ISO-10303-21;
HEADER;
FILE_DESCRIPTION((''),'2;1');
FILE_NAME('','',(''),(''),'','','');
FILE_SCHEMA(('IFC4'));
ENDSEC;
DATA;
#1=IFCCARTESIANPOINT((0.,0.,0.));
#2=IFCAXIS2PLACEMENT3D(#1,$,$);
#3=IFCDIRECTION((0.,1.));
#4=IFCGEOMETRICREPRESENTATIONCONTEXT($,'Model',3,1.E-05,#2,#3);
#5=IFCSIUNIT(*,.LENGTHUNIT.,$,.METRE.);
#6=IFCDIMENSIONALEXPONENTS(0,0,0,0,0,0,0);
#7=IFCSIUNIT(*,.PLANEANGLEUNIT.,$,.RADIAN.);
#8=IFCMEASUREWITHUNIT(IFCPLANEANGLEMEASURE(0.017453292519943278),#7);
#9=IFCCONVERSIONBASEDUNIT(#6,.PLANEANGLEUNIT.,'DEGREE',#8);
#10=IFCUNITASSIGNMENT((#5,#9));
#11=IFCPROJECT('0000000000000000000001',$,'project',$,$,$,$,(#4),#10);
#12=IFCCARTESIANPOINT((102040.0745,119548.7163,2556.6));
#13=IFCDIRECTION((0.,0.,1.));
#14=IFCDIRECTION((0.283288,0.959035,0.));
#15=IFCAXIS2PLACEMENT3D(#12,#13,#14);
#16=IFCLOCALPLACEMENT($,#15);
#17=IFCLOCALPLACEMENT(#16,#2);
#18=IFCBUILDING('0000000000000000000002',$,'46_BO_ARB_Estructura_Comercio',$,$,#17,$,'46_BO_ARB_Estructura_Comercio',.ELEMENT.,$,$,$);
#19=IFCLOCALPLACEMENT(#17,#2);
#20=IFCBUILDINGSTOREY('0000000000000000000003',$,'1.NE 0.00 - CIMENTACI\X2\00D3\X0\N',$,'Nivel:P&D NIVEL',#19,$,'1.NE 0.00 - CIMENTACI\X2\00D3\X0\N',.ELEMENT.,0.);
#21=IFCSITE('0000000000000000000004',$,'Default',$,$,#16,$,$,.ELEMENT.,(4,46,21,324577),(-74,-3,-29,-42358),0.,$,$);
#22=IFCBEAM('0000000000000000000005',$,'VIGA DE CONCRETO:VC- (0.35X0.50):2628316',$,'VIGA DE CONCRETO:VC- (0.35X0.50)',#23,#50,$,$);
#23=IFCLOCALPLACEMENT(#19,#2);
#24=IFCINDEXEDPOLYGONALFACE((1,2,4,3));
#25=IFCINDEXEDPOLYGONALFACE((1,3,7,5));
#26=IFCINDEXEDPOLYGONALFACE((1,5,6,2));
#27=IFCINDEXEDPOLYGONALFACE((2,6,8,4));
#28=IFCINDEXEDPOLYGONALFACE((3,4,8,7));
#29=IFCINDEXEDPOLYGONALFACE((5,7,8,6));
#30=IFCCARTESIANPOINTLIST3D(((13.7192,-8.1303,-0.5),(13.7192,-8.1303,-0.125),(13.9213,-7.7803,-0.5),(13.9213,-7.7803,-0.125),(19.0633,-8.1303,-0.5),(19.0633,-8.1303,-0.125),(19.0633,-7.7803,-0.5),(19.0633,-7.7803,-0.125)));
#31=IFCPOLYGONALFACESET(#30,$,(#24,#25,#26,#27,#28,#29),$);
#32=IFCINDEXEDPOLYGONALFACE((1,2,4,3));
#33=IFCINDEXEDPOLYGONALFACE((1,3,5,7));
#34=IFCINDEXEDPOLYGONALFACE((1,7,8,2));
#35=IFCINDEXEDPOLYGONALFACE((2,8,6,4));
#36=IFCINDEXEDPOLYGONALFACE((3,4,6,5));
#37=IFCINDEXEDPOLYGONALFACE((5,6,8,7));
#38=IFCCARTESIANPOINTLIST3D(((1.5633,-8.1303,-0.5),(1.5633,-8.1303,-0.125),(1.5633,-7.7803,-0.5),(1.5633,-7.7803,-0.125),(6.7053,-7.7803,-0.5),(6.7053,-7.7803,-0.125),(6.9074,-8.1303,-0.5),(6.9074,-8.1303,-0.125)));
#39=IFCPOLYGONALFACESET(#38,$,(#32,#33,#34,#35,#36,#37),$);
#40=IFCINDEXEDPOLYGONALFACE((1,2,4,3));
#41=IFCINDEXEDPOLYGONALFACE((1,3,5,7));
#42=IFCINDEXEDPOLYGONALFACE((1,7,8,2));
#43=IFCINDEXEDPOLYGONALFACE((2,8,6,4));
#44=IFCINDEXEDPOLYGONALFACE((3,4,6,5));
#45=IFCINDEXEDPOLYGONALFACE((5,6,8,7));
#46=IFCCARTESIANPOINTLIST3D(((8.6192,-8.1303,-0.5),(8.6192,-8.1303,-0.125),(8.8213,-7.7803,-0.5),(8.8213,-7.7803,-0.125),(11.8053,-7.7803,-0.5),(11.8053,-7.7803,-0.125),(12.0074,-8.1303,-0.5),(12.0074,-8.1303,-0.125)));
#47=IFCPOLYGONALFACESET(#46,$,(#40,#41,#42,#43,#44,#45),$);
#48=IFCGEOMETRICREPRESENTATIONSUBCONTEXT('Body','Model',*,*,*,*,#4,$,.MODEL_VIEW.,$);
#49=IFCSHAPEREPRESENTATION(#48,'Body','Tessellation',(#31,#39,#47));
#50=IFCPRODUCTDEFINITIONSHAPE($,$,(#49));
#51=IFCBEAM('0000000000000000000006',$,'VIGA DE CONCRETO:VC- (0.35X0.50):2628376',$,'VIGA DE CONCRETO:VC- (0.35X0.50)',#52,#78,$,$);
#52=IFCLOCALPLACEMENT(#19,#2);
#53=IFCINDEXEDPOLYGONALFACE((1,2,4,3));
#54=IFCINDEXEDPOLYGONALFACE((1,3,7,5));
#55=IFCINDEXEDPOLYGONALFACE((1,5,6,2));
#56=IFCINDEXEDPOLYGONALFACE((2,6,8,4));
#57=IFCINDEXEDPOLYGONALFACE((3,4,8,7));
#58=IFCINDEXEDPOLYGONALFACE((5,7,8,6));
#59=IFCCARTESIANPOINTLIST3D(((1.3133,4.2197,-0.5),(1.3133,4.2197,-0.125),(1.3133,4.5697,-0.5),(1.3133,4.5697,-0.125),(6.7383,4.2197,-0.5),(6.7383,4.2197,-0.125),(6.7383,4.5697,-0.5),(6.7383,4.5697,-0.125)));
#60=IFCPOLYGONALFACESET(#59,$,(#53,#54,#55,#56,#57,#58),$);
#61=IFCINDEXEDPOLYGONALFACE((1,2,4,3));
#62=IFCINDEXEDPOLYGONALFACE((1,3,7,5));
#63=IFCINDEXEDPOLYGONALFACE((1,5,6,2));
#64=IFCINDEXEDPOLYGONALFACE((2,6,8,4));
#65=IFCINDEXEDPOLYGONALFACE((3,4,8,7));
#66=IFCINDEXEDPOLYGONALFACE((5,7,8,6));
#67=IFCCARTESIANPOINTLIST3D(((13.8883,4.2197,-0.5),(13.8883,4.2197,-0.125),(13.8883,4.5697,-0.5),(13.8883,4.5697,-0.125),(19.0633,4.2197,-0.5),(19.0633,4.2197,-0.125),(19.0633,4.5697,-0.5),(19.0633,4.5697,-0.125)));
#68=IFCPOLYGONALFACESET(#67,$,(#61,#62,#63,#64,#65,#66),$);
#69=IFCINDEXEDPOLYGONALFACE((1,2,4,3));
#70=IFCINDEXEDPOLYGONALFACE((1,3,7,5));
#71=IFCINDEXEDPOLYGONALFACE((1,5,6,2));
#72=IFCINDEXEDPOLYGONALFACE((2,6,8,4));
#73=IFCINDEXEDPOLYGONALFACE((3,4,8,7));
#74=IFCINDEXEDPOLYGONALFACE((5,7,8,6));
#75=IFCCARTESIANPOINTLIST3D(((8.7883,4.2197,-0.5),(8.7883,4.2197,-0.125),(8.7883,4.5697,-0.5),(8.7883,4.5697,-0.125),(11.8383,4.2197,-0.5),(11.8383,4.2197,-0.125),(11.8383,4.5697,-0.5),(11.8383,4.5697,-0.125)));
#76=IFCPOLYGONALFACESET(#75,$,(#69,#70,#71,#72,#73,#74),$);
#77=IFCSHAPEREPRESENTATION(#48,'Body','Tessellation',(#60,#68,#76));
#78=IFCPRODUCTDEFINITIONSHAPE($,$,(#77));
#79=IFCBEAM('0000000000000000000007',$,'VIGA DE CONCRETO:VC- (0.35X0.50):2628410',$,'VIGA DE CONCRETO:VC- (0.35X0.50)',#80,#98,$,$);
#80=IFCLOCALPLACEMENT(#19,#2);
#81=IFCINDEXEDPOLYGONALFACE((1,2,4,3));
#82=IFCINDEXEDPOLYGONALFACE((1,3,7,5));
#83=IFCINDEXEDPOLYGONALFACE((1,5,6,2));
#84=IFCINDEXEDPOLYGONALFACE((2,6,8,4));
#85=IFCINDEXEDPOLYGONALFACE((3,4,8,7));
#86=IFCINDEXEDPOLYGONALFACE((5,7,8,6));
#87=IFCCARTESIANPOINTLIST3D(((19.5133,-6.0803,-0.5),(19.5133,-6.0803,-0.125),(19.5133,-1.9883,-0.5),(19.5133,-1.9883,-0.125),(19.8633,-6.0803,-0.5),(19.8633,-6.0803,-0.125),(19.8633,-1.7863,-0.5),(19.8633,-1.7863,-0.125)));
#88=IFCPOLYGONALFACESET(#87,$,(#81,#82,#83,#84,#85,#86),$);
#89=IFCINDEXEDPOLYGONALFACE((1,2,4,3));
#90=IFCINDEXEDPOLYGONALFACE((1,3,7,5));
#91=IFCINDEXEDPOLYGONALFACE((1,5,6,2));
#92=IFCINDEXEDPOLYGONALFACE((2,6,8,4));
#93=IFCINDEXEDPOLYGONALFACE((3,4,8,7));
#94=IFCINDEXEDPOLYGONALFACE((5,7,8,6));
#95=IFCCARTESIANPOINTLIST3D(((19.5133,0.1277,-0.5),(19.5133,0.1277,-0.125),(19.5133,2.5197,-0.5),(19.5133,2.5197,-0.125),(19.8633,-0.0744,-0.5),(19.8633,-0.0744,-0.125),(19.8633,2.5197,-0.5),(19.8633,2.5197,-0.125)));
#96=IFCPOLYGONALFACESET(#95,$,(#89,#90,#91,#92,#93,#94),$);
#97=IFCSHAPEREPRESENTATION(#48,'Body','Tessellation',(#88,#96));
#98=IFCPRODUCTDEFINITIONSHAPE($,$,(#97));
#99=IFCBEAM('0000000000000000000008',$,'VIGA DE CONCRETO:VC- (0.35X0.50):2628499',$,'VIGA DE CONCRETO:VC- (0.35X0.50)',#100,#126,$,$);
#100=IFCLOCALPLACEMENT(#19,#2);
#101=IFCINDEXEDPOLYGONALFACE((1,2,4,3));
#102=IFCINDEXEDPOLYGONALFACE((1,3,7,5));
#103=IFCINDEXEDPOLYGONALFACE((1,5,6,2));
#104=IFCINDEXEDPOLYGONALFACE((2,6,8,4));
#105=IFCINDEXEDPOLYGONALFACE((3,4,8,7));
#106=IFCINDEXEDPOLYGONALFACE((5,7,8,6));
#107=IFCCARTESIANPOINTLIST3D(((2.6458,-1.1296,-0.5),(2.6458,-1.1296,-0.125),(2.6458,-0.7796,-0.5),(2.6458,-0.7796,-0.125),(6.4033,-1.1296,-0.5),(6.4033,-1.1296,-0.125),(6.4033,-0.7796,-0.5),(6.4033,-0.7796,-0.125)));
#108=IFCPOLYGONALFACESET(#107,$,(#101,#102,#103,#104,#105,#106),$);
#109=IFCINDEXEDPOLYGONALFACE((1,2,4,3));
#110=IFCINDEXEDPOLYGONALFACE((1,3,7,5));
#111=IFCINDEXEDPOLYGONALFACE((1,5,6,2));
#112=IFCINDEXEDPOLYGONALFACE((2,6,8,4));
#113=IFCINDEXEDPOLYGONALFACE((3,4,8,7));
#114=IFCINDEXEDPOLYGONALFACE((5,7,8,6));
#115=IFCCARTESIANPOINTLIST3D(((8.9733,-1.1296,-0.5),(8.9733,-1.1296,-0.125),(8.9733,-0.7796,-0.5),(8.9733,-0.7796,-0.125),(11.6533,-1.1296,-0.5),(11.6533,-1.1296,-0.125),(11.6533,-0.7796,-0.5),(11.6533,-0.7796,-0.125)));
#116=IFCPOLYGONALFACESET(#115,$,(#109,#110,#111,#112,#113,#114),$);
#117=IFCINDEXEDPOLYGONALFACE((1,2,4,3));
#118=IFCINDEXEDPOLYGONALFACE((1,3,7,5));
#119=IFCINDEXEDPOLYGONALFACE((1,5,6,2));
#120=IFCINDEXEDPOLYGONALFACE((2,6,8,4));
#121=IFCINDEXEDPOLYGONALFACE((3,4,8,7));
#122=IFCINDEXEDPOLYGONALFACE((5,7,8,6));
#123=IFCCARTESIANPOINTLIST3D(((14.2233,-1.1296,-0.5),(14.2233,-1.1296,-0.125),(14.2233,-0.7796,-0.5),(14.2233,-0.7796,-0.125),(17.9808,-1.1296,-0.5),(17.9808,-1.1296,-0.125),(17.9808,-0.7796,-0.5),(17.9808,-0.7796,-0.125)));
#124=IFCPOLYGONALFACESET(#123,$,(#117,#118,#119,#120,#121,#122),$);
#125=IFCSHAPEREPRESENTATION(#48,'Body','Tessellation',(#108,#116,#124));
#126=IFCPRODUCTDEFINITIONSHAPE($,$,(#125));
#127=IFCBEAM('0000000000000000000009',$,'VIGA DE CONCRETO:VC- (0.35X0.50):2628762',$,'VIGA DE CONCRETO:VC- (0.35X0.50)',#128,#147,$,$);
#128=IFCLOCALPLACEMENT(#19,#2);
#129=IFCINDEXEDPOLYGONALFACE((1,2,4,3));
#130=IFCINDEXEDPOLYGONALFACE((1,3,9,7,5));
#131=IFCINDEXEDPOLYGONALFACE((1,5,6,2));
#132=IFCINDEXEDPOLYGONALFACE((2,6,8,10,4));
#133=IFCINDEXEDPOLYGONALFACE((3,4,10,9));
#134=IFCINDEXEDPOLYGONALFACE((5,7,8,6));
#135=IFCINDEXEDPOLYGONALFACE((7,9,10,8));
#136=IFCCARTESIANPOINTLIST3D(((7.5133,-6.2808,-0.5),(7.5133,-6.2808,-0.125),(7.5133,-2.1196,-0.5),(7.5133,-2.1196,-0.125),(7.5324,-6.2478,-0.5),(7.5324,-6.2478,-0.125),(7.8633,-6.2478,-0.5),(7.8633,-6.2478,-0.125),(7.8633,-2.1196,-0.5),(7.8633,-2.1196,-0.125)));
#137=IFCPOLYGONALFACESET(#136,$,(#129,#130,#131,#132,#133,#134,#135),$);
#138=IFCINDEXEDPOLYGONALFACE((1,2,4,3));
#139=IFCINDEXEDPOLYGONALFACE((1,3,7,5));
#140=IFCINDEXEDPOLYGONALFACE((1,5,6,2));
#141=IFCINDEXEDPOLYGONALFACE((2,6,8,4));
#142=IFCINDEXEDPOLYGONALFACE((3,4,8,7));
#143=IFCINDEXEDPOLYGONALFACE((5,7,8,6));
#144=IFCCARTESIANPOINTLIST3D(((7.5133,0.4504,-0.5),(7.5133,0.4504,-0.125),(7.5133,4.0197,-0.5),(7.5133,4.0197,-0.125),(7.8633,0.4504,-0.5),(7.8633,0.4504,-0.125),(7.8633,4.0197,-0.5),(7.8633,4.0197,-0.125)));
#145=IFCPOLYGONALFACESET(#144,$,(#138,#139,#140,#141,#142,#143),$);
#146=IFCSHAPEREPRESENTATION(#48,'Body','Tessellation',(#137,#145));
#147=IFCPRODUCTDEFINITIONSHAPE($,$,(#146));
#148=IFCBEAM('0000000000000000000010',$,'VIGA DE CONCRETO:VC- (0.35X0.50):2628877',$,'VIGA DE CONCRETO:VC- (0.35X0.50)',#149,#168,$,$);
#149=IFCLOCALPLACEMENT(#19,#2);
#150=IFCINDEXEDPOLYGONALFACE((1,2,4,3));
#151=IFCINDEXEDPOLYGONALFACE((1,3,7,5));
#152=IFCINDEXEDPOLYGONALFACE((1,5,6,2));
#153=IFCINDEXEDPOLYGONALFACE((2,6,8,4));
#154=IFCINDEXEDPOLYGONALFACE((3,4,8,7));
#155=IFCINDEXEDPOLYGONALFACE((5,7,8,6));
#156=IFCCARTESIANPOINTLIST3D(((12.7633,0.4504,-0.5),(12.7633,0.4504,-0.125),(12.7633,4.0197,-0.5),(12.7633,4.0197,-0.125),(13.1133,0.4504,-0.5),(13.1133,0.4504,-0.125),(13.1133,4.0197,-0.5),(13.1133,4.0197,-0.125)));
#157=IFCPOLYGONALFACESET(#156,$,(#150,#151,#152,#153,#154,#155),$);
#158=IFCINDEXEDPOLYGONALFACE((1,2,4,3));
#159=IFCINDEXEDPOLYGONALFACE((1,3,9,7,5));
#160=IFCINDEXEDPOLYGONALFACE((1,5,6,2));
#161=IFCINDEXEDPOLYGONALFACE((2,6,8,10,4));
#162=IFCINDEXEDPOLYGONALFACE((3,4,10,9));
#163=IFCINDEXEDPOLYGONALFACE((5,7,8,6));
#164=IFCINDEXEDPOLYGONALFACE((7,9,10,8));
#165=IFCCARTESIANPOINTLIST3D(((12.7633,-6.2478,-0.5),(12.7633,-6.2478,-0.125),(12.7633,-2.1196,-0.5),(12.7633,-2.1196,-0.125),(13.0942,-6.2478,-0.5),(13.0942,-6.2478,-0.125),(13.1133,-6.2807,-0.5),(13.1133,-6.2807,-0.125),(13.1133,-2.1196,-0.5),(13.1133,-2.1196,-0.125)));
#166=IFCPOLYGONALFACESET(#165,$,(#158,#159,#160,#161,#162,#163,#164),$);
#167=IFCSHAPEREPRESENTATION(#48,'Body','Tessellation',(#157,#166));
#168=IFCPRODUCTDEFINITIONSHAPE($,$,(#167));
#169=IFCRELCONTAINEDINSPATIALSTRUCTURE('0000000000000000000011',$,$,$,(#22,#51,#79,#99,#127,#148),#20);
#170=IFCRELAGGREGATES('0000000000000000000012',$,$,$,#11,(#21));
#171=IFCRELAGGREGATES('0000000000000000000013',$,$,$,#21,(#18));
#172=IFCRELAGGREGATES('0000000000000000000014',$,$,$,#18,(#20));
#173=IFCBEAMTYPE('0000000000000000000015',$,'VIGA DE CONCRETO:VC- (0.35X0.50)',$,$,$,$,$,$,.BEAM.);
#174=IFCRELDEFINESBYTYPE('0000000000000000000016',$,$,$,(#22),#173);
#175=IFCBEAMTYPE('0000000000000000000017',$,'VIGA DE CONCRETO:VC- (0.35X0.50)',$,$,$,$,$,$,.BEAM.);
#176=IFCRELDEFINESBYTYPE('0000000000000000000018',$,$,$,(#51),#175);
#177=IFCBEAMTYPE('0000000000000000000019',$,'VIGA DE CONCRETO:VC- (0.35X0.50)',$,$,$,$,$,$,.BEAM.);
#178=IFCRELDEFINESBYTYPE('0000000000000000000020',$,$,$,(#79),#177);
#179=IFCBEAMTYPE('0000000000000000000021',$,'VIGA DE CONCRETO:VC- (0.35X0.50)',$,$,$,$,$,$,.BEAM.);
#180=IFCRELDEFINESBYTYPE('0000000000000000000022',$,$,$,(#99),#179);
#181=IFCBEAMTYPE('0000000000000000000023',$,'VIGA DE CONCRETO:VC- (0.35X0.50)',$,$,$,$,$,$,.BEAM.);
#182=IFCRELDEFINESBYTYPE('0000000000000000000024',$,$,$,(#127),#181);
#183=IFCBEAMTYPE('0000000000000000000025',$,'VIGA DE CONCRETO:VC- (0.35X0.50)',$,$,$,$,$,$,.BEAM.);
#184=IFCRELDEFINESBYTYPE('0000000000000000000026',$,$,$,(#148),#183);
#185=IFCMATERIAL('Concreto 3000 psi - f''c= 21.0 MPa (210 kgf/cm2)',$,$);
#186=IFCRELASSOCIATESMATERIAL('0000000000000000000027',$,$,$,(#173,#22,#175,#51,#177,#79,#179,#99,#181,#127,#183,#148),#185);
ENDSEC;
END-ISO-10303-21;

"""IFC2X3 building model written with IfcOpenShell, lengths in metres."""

from ifc_helpers import new_model, entity, si_unit, converted_unit, direction, frame, frame_2d, origin, origin_2d_with_axis, place, context, subcontext, project, spatial, polyline, rectangle, extrude, clip, halfspace, bounded_halfspace, source, transform, mapped, material, type_object, type_shapes, element, save


model = new_model("IFC2X3")

# Units and contexts
model_context = context("Model", 3, precision=1e-05, world=origin(), true_north=direction((0.0, 1.0)))
body_context = subcontext(model_context, "Body", "Model", "MODEL_VIEW")
ifc_project = project(units=[si_unit("LENGTHUNIT", "METRE"), converted_unit("PLANEANGLEUNIT", "DEGREE", entity("IfcPlaneAngleMeasure", 0.017453292519943278), si_unit("PLANEANGLEUNIT", "RADIAN"), dimensions=[0, 0, 0, 0, 0, 0, 0])], contexts=[model_context])

# Site, building, storey
site_placement = place(None, frame((102040.0745, 119548.7163, 2556.6), z_axis=(0.0, 0.0, 1.0), x_axis=(0.283288, 0.959035, 0.0)))
site = spatial("IfcSite", under=ifc_project, at=site_placement, Name="Default", CompositionType="ELEMENT", RefLatitude=(4, 46, 21, 324577), RefLongitude=(-74, -3, -29, -42358), RefElevation=0.0)
building_placement = place(site_placement, origin())
building = spatial("IfcBuilding", under=site, at=building_placement, Name="46_BO_ARB_Estructura_Comercio", LongName="46_BO_ARB_Estructura_Comercio", CompositionType="ELEMENT")
storey_placement = place(building_placement, origin())
storey = spatial("IfcBuildingStorey", under=building, at=storey_placement, Name="1.NE 0.00 - CIMENTACIÓN", ObjectType="Nivel:P&D NIVEL", LongName="1.NE 0.00 - CIMENTACIÓN", CompositionType="ELEMENT", Elevation=0.0)

# Beams
ifc_material_1 = material(Name="Concreto 3000 psi - f'c= 21.0 MPa (210 kgf/cm2)")
beam_type_1 = type_object("IfcBeamType", Name="VIGA DE CONCRETO:VC- (0.35X0.50)", PredefinedType="BEAM", material=ifc_material_1)
shared_shape_1 = source(origin(), body_context, "Body", "SweptSolid", [
    clip(extrude(rectangle(XDim=0.375, YDim=0.35, at=frame_2d((0.0, 0.0), x_axis=(1.0, 0.0))), frame((13.7192, -7.9553, -0.3125), z_axis=(1.0, 0.0, 0.0), x_axis=(0.0, 0.0, -1.0)), (0.0, 0.0, 1.0), 5.3441), halfspace(frame((13.7192, -8.1303, 0.0), z_axis=(-0.866026, 0.499999, 0.0), x_axis=(0.0, 0.0, -1.0)), False)),
    clip(extrude(rectangle(XDim=0.375, YDim=0.35, at=frame_2d((0.0, 0.0), x_axis=(1.0, 0.0))), frame((1.5633, -7.9553, -0.3125), z_axis=(1.0, 0.0, 0.0), x_axis=(0.0, 0.0, -1.0)), (0.0, 0.0, 1.0), 5.3441), halfspace(frame((6.6764, -7.7303, 0.0), z_axis=(0.866026, 0.5, 0.0), x_axis=(0.0, 0.0, -1.0)), False)),
    clip(clip(extrude(rectangle(XDim=0.375, YDim=0.35, at=frame_2d((0.0, 0.0), x_axis=(1.0, 0.0))), frame((8.6192, -7.9553, -0.3125), z_axis=(1.0, 0.0, 0.0), x_axis=(0.0, 0.0, -1.0)), (0.0, 0.0, 1.0), 3.3881), halfspace(frame((8.6192, -8.1303, 0.0), z_axis=(-0.866026, 0.499999, 0.0), x_axis=(0.0, 0.0, -1.0)), False)), halfspace(frame((11.7764, -7.7303, 0.0), z_axis=(0.866026, 0.5, 0.0), x_axis=(0.0, 0.0, -1.0)), False)),
])
type_shapes(beam_type_1, [shared_shape_1])
beam_1_placement = place(storey_placement, origin())
element("IfcBeam", 1, at=beam_1_placement, inside=storey, type_object=beam_type_1, material=ifc_material_1, Name="VIGA DE CONCRETO:VC- (0.35X0.50):2628316", ObjectType="VIGA DE CONCRETO:VC- (0.35X0.50)", context=body_context, shape_type="MappedRepresentation", body=[
    mapped(shared_shape_1, transform((0.0, 0.0, 0.0), scale=1.0)),
])
beam_type_2 = type_object("IfcBeamType", Name="VIGA DE CONCRETO:VC- (0.35X0.50)", PredefinedType="BEAM", material=ifc_material_1)
shared_shape_2 = source(origin(), body_context, "Body", "SweptSolid", [
    extrude(rectangle(XDim=0.375, YDim=0.35, at=frame_2d((0.0, 0.0), x_axis=(1.0, 0.0))), frame((1.3133, 4.3947, -0.3125), z_axis=(1.0, 0.0, 0.0), x_axis=(0.0, 0.0, -1.0)), (0.0, 0.0, 1.0), 5.425),
    extrude(rectangle(XDim=0.375, YDim=0.35, at=frame_2d((0.0, 0.0), x_axis=(1.0, 0.0))), frame((13.8883, 4.3947, -0.3125), z_axis=(1.0, 0.0, 0.0), x_axis=(0.0, 0.0, -1.0)), (0.0, 0.0, 1.0), 5.175),
    extrude(rectangle(XDim=0.375, YDim=0.35, at=frame_2d((0.0, 0.0), x_axis=(1.0, 0.0))), frame((8.7883, 4.3947, -0.3125), z_axis=(1.0, 0.0, 0.0), x_axis=(0.0, 0.0, -1.0)), (0.0, 0.0, 1.0), 3.05),
])
type_shapes(beam_type_2, [shared_shape_2])
beam_2_placement = place(storey_placement, origin())
element("IfcBeam", 2, at=beam_2_placement, inside=storey, type_object=beam_type_2, material=ifc_material_1, Name="VIGA DE CONCRETO:VC- (0.35X0.50):2628376", ObjectType="VIGA DE CONCRETO:VC- (0.35X0.50)", context=body_context, shape_type="MappedRepresentation", body=[
    mapped(shared_shape_2, transform((0.0, 0.0, 0.0), scale=1.0)),
])
beam_type_3 = type_object("IfcBeamType", Name="VIGA DE CONCRETO:VC- (0.35X0.50)", PredefinedType="BEAM", material=ifc_material_1)
shared_shape_3 = source(origin(), body_context, "Body", "SweptSolid", [
    clip(extrude(rectangle(XDim=0.375, YDim=0.35, at=frame_2d((0.0, 0.0), x_axis=(0.0, 1.0))), frame((19.6883, -6.0803, -0.3125), z_axis=(0.0, 1.0, 0.0), x_axis=(-1.0, 0.0, 0.0)), (0.0, 0.0, 1.0), 4.2941), halfspace(frame((19.4633, -2.0172, 0.0), z_axis=(-0.5, 0.866026, 0.0), x_axis=(0.0, 0.0, -1.0)), False)),
    clip(extrude(rectangle(XDim=0.375, YDim=0.35, at=frame_2d((0.0, 0.0), x_axis=(0.0, 1.0))), frame((19.6883, -0.0744, -0.3125), z_axis=(0.0, 1.0, 0.0), x_axis=(-1.0, 0.0, 0.0)), (0.0, 0.0, 1.0), 2.5941), halfspace(frame((19.8633, -0.0744, 0.0), z_axis=(-0.499999, -0.866026, 0.0), x_axis=(0.0, 0.0, -1.0)), False)),
])
type_shapes(beam_type_3, [shared_shape_3])
beam_3_placement = place(storey_placement, origin())
element("IfcBeam", 3, at=beam_3_placement, inside=storey, type_object=beam_type_3, material=ifc_material_1, Name="VIGA DE CONCRETO:VC- (0.35X0.50):2628410", ObjectType="VIGA DE CONCRETO:VC- (0.35X0.50)", context=body_context, shape_type="MappedRepresentation", body=[
    mapped(shared_shape_3, transform((0.0, 0.0, 0.0), scale=1.0)),
])
beam_type_4 = type_object("IfcBeamType", Name="VIGA DE CONCRETO:VC- (0.35X0.50)", PredefinedType="BEAM", material=ifc_material_1)
shared_shape_4 = source(origin(), body_context, "Body", "SweptSolid", [
    extrude(rectangle(XDim=0.375, YDim=0.35, at=frame_2d((0.0, 0.0), x_axis=(1.0, 0.0))), frame((2.6458, -0.9546, -0.3125), z_axis=(1.0, 0.0, 0.0), x_axis=(0.0, 0.0, -1.0)), (0.0, 0.0, 1.0), 3.7575),
    extrude(rectangle(XDim=0.375, YDim=0.35, at=frame_2d((0.0, 0.0), x_axis=(1.0, 0.0))), frame((8.9733, -0.9546, -0.3125), z_axis=(1.0, 0.0, 0.0), x_axis=(0.0, 0.0, -1.0)), (0.0, 0.0, 1.0), 2.68),
    extrude(rectangle(XDim=0.375, YDim=0.35, at=origin_2d_with_axis()), frame((14.2233, -0.9546, -0.3125), z_axis=(1.0, 0.0, 0.0), x_axis=(0.0, 0.0, -1.0)), (0.0, 0.0, 1.0), 3.7575),
])
type_shapes(beam_type_4, [shared_shape_4])
beam_4_placement = place(storey_placement, origin())
element("IfcBeam", 4, at=beam_4_placement, inside=storey, type_object=beam_type_4, material=ifc_material_1, Name="VIGA DE CONCRETO:VC- (0.35X0.50):2628499", ObjectType="VIGA DE CONCRETO:VC- (0.35X0.50)", context=body_context, shape_type="MappedRepresentation", body=[
    mapped(shared_shape_4, transform((0.0, 0.0, 0.0), scale=1.0)),
])
beam_type_5 = type_object("IfcBeamType", Name="VIGA DE CONCRETO:VC- (0.35X0.50)", PredefinedType="BEAM", material=ifc_material_1)
shared_shape_5 = source(origin(), body_context, "Body", "SweptSolid", [
    clip(clip(extrude(rectangle(XDim=0.375, YDim=0.35, at=frame_2d((0.0, 0.0), x_axis=(1.0, 0.0))), frame((7.6883, -6.2808, -0.3125), z_axis=(0.0, 1.0, 0.0), x_axis=(0.0, 0.0, 1.0)), (0.0, 0.0, 1.0), 4.1612), bounded_halfspace(frame((7.9942, -6.2478, 0.0), z_axis=(0.0, -1.0, 0.0), x_axis=(0.0, 0.0, -1.0)), False, frame((7.6883, -6.2808, -0.3125), z_axis=(0.0, 1.0, 0.0), x_axis=(0.0, 0.0, 1.0)), polyline([(-0.1875, -0.1559), (-0.1875, 0.175), (0.1875, 0.175), (0.1875, -0.1559), (-0.1875, -0.1559)]))), bounded_halfspace(frame((7.5324, -6.2478, 0.0), z_axis=(0.866025, -0.5, 0.0), x_axis=(0.0, 0.0, -1.0)), False, frame((7.6883, -6.2808, -0.3125), z_axis=(0.0, 1.0, 0.0), x_axis=(0.0, 0.0, 1.0)), polyline([(-0.1875, -0.175), (-0.1875, -0.1559), (0.1875, -0.1559), (0.1875, -0.175), (-0.1875, -0.175)]))),
    extrude(rectangle(XDim=0.375, YDim=0.35, at=frame_2d((0.0, 0.0), x_axis=(0.0, 1.0))), frame((7.6883, 0.4504, -0.3125), z_axis=(0.0, 1.0, 0.0), x_axis=(-1.0, 0.0, 0.0)), (0.0, 0.0, 1.0), 3.5693),
])
type_shapes(beam_type_5, [shared_shape_5])
beam_5_placement = place(storey_placement, origin())
element("IfcBeam", 5, at=beam_5_placement, inside=storey, type_object=beam_type_5, material=ifc_material_1, Name="VIGA DE CONCRETO:VC- (0.35X0.50):2628762", ObjectType="VIGA DE CONCRETO:VC- (0.35X0.50)", context=body_context, shape_type="MappedRepresentation", body=[
    mapped(shared_shape_5, transform((0.0, 0.0, 0.0), scale=1.0)),
])
beam_type_6 = type_object("IfcBeamType", Name="VIGA DE CONCRETO:VC- (0.35X0.50)", PredefinedType="BEAM", material=ifc_material_1)
shared_shape_6 = source(origin(), body_context, "Body", "SweptSolid", [
    extrude(rectangle(XDim=0.375, YDim=0.35, at=frame_2d((0.0, 0.0), x_axis=(0.0, 1.0))), frame((12.9383, 4.0197, -0.3125), z_axis=(0.0, -1.0, 0.0), x_axis=(-1.0, 0.0, 0.0)), (0.0, 0.0, 1.0), 3.5693),
    clip(clip(extrude(rectangle(XDim=0.375, YDim=0.35, at=frame_2d((0.0, 0.0), x_axis=(1.0, 0.0))), frame((12.9383, -2.1196, -0.3125), z_axis=(0.0, -1.0, 0.0), x_axis=(0.0, 0.0, -1.0)), (0.0, 0.0, 1.0), 4.1611), bounded_halfspace(frame((13.9502, -7.7303, 0.0), z_axis=(-0.866025, -0.5, 0.0), x_axis=(0.0, 0.0, -1.0)), False, frame((12.9383, -2.1196, -0.3125), z_axis=(0.0, -1.0, 0.0), x_axis=(0.0, 0.0, -1.0)), polyline([(0.1875, 0.156), (0.1875, 0.175), (-0.1875, 0.175), (-0.1875, 0.156), (0.1875, 0.156)]))), bounded_halfspace(frame((13.0942, -6.2478, 0.0), z_axis=(0.0, -1.0, 0.0), x_axis=(0.0, 0.0, -1.0)), False, frame((12.9383, -2.1196, -0.3125), z_axis=(0.0, -1.0, 0.0), x_axis=(0.0, 0.0, -1.0)), polyline([(0.1875, -0.175), (0.1875, 0.156), (-0.1875, 0.156), (-0.1875, -0.175), (0.1875, -0.175)]))),
])
type_shapes(beam_type_6, [shared_shape_6])
beam_6_placement = place(storey_placement, origin())
element("IfcBeam", 6, at=beam_6_placement, inside=storey, type_object=beam_type_6, material=ifc_material_1, Name="VIGA DE CONCRETO:VC- (0.35X0.50):2628877", ObjectType="VIGA DE CONCRETO:VC- (0.35X0.50)", context=body_context, shape_type="MappedRepresentation", body=[
    mapped(shared_shape_6, transform((0.0, 0.0, 0.0), scale=1.0)),
])

save(model, "model.ifc")
